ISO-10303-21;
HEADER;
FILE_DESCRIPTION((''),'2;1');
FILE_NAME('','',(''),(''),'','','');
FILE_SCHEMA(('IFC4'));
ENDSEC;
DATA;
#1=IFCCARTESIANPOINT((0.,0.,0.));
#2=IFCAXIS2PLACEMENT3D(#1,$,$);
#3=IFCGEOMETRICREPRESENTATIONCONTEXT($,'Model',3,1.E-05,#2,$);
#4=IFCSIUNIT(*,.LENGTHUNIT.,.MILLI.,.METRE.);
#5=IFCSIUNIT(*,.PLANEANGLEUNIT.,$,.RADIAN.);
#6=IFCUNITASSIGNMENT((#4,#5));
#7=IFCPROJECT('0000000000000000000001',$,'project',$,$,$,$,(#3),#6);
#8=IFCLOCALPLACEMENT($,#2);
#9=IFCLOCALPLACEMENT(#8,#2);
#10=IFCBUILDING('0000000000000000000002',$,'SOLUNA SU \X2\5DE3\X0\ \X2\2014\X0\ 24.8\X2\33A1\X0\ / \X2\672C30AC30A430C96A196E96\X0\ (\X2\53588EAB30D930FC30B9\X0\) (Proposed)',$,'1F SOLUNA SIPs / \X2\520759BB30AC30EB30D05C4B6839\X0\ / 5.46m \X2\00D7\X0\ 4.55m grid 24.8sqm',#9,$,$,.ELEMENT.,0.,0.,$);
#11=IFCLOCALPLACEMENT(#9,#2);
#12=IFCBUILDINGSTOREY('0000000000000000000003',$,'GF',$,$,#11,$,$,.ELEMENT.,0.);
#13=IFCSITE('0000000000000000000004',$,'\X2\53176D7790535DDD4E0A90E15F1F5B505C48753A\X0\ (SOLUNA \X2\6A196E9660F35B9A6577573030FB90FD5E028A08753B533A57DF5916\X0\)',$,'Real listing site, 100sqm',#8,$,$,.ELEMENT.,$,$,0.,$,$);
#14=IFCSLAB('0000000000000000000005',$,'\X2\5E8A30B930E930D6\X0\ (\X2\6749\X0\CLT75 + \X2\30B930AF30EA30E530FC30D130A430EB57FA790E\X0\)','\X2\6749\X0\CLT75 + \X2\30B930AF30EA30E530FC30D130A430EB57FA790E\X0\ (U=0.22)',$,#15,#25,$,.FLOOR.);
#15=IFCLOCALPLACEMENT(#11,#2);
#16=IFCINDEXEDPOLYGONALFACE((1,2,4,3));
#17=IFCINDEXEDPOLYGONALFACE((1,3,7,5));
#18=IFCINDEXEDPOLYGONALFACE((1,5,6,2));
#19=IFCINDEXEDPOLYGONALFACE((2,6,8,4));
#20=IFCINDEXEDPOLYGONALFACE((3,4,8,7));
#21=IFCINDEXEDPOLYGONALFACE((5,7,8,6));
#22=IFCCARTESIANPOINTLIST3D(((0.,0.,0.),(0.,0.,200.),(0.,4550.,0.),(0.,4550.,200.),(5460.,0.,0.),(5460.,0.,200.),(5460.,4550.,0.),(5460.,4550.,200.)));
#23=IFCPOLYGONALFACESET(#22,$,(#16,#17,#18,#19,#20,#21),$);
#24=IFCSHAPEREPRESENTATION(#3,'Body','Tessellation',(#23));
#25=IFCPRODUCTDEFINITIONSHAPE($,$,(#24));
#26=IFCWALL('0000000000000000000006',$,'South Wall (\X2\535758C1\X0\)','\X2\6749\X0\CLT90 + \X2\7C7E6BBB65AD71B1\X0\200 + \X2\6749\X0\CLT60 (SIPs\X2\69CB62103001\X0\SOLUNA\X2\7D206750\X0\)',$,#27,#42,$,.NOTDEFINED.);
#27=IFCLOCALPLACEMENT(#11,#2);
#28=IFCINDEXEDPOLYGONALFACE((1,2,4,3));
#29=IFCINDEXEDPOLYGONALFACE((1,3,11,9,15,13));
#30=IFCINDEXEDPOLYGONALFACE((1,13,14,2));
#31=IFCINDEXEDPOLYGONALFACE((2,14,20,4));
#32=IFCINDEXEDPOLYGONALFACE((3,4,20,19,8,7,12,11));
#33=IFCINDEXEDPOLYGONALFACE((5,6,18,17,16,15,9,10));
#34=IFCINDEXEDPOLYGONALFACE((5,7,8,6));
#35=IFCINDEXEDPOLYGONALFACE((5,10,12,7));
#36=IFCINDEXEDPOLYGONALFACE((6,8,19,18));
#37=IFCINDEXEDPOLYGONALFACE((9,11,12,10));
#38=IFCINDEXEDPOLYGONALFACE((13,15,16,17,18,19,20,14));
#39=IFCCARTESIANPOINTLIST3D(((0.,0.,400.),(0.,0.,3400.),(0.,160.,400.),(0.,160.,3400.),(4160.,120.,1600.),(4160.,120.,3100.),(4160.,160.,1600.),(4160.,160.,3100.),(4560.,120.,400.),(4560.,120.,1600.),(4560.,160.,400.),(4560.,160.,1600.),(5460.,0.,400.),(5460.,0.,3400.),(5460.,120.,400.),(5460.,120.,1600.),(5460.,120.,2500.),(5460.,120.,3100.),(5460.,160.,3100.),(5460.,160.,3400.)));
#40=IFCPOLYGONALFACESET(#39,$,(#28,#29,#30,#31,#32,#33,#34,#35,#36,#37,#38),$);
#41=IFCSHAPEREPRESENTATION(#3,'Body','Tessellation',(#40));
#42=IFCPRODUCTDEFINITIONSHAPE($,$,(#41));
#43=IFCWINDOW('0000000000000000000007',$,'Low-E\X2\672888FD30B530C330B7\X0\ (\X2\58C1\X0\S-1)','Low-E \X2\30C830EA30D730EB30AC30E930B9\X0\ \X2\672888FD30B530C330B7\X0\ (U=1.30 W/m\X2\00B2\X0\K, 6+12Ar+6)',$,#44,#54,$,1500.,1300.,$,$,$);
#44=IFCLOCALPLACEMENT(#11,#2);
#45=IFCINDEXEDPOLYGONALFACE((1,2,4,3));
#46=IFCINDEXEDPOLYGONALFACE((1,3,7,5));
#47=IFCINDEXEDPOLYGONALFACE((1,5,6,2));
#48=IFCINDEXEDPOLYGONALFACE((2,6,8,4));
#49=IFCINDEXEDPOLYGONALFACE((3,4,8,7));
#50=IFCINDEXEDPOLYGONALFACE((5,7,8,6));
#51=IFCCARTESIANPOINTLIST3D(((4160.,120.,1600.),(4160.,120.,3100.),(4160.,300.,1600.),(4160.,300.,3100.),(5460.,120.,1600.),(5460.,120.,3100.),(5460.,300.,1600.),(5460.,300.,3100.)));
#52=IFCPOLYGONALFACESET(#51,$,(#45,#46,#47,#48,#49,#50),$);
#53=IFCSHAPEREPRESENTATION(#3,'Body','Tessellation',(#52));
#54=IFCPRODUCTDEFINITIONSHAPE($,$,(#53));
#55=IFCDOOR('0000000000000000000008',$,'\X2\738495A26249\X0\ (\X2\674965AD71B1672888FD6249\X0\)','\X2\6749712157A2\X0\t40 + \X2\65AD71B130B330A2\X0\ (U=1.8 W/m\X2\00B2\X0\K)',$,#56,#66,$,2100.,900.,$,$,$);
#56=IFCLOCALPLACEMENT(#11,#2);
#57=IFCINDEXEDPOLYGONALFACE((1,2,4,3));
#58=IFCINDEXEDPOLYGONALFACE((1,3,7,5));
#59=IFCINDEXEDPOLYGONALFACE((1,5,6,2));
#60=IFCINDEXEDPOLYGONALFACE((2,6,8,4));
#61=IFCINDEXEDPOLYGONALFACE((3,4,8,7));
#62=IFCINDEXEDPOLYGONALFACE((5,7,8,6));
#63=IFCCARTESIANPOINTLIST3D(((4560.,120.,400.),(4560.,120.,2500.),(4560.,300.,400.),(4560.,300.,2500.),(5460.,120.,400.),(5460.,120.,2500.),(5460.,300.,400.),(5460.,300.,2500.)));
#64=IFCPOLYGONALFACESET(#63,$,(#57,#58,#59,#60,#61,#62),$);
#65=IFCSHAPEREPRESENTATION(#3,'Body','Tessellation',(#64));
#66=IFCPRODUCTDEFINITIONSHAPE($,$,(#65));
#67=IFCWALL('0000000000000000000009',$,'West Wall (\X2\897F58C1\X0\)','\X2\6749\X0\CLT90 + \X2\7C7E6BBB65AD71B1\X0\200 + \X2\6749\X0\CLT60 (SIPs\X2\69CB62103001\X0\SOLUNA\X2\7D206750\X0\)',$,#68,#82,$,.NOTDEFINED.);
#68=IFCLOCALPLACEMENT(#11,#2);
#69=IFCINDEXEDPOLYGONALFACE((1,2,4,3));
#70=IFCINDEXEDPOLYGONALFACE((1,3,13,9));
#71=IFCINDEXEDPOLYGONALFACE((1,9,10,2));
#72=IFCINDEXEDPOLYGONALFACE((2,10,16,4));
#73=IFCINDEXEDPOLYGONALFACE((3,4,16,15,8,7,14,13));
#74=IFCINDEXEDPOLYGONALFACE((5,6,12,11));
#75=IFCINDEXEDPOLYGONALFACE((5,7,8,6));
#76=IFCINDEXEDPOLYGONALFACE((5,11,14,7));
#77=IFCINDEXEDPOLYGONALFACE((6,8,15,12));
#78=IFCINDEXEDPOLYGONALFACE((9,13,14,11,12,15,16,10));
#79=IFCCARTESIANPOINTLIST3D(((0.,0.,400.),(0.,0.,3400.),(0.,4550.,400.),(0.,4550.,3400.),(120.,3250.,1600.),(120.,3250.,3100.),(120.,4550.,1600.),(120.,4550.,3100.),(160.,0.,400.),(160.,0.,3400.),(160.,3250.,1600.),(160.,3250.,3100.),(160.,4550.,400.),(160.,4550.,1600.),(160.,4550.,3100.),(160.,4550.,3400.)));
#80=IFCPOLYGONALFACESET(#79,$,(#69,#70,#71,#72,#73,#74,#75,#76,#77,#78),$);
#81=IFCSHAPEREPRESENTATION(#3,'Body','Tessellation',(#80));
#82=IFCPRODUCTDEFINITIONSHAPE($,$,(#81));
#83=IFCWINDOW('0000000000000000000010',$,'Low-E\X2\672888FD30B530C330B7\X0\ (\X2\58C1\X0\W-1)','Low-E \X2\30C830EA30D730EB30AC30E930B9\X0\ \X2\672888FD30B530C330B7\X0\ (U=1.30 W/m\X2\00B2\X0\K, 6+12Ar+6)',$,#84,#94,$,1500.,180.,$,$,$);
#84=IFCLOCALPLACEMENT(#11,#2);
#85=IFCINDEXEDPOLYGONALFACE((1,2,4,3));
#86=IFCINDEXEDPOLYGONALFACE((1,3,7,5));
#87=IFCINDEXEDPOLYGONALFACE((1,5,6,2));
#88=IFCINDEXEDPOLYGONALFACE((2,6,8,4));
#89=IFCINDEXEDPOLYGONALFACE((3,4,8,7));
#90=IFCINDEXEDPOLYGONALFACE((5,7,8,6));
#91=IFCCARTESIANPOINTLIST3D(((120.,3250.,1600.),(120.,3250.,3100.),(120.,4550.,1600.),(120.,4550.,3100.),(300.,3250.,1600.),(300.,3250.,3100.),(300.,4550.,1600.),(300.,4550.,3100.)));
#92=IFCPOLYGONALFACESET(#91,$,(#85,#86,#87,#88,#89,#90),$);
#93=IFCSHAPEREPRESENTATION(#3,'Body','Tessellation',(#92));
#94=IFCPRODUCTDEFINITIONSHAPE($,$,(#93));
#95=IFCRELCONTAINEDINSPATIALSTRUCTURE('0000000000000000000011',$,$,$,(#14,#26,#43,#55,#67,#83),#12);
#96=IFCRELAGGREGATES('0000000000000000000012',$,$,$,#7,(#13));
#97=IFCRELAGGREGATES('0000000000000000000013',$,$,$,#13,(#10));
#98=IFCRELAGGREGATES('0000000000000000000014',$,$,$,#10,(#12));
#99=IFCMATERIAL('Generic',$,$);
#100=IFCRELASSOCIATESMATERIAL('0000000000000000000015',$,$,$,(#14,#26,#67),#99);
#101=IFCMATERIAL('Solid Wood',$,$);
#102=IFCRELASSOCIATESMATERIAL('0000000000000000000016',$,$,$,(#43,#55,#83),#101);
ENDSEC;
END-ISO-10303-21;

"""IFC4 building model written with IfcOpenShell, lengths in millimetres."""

from ifc_helpers import new_model, si_unit, frame, frame_2d, origin, place, context, project, spatial, rectangle, extrude, material, element, fill, save


model = new_model("IFC4")

# Units and contexts
model_context = context("Model", 3, precision=1e-05, world=origin())
ifc_project = project(units=[si_unit("LENGTHUNIT", "METRE", prefix="MILLI"), si_unit("PLANEANGLEUNIT", "RADIAN")], contexts=[model_context])

# Site, building, storey
site_placement = place(None, origin())
site = spatial("IfcSite", under=ifc_project, at=site_placement, Name="北海道川上郡弟子屈町 (SOLUNA 標準想定敷地・都市計画区域外)", ObjectType="Real listing site, 100sqm", CompositionType="ELEMENT", RefElevation=0.0)
building_placement = place(site_placement, origin())
building = spatial("IfcBuilding", under=site, at=building_placement, Name="SOLUNA SU 巣 — 24.8㎡ / 本ガイド標準 (単身ベース) (Proposed)", ObjectType="1F SOLUNA SIPs / 切妻ガルバ屋根 / 5.46m × 4.55m grid 24.8sqm", CompositionType="ELEMENT", ElevationOfRefHeight=0.0, ElevationOfTerrain=0.0)
storey_placement = place(building_placement, origin())
storey = spatial("IfcBuildingStorey", under=building, at=storey_placement, Name="GF", CompositionType="ELEMENT", Elevation=0.0)

# Slab
ifc_material_1 = material(Name="Generic")
slab_placement = place(storey_placement, origin())
element("IfcSlab", 1, at=slab_placement, inside=storey, material=ifc_material_1, Name="床スラブ (杉CLT75 + スクリューパイル基礎)", Description="杉CLT75 + スクリューパイル基礎 (U=0.22)", PredefinedType="FLOOR", context=model_context, shape_type="SweptSolid", body=[
    extrude(rectangle(XDim=5460.0, YDim=4550.0, at=frame_2d((2730.0, 2275.0))), origin(), (0.0, 0.0, 1.0), 200.0),
])

# Wall, openings, window, door
wall_1_placement = place(storey_placement, frame((0.0, 0.0, 200.0)))
wall_1 = element("IfcWall", 2, at=wall_1_placement, inside=storey, material=ifc_material_1, Name="South Wall (南壁)", Description="杉CLT90 + 籾殻断熱200 + 杉CLT60 (SIPs構成、SOLUNA素材)", PredefinedType="NOTDEFINED", context=model_context, shape_type="SweptSolid", body=[
    extrude(rectangle(XDim=5460.0, YDim=160.0, at=frame_2d((2730.0, 80.0))), frame((0.0, 0.0, 200.0)), (0.0, 0.0, 1.0), 3000.0),
])
opening_1_placement = place(storey_placement, frame((2080.0, 60.0, 800.0)))
opening_1 = element("IfcOpeningElement", 3, at=opening_1_placement, cuts=wall_1, PredefinedType="NOTDEFINED", context=model_context, shape_type="SweptSolid", body=[
    extrude(rectangle(XDim=1300.0, YDim=180.0, at=frame_2d((650.0, 90.0))), frame((2080.0, 60.0, 800.0)), (0.0, 0.0, 1.0), 1500.0),
])
opening_2_placement = place(storey_placement, frame((2280.0, 60.0, 200.0)))
opening_2 = element("IfcOpeningElement", 4, at=opening_2_placement, cuts=wall_1, PredefinedType="NOTDEFINED", context=model_context, shape_type="SweptSolid", body=[
    extrude(rectangle(XDim=900.0, YDim=180.0, at=frame_2d((450.0, 90.0))), frame((2280.0, 60.0, 200.0)), (0.0, 0.0, 1.0), 2100.0),
])
ifc_material_2 = material(Name="Solid Wood")
window_1_placement = place(storey_placement, frame((2080.0, 60.0, 800.0)))
window_1 = element("IfcWindow", 5, at=window_1_placement, inside=storey, material=ifc_material_2, Name="Low-E木製サッシ (壁S-1)", Description="Low-E トリプルガラス 木製サッシ (U=1.30 W/m²K, 6+12Ar+6)", OverallHeight=1500.0, OverallWidth=1300.0, context=model_context, shape_type="SweptSolid", body=[
    extrude(rectangle(XDim=1300.0, YDim=180.0, at=frame_2d((650.0, 90.0))), frame((2080.0, 60.0, 800.0)), (0.0, 0.0, 1.0), 1500.0),
])
fill(opening_1, window_1)
door_placement = place(storey_placement, frame((2280.0, 60.0, 200.0)))
door = element("IfcDoor", 6, at=door_placement, inside=storey, material=ifc_material_2, Name="玄関扉 (杉断熱木製扉)", Description="杉無垢t40 + 断熱コア (U=1.8 W/m²K)", OverallHeight=2100.0, OverallWidth=900.0, context=model_context, shape_type="SweptSolid", body=[
    extrude(rectangle(XDim=900.0, YDim=180.0, at=frame_2d((450.0, 90.0))), frame((2280.0, 60.0, 200.0)), (0.0, 0.0, 1.0), 2100.0),
])
fill(opening_2, door)

# Wall, opening, window
wall_2_placement = place(storey_placement, frame((0.0, 0.0, 200.0)))
wall_2 = element("IfcWall", 7, at=wall_2_placement, inside=storey, material=ifc_material_1, Name="West Wall (西壁)", Description="杉CLT90 + 籾殻断熱200 + 杉CLT60 (SIPs構成、SOLUNA素材)", PredefinedType="NOTDEFINED", context=model_context, shape_type="SweptSolid", body=[
    extrude(rectangle(XDim=160.0, YDim=4550.0, at=frame_2d((80.0, 2275.0))), frame((0.0, 0.0, 200.0)), (0.0, 0.0, 1.0), 3000.0),
])
opening_3_placement = place(storey_placement, frame((60.0, 1625.0, 800.0)))
opening_3 = element("IfcOpeningElement", 8, at=opening_3_placement, cuts=wall_2, PredefinedType="NOTDEFINED", context=model_context, shape_type="SweptSolid", body=[
    extrude(rectangle(XDim=180.0, YDim=1300.0, at=frame_2d((90.0, 650.0))), frame((60.0, 1625.0, 800.0)), (0.0, 0.0, 1.0), 1500.0),
])
window_2_placement = place(storey_placement, frame((60.0, 1625.0, 800.0)))
window_2 = element("IfcWindow", 9, at=window_2_placement, inside=storey, material=ifc_material_2, Name="Low-E木製サッシ (壁W-1)", Description="Low-E トリプルガラス 木製サッシ (U=1.30 W/m²K, 6+12Ar+6)", OverallHeight=1500.0, OverallWidth=180.0, context=model_context, shape_type="SweptSolid", body=[
    extrude(rectangle(XDim=180.0, YDim=1300.0, at=frame_2d((90.0, 650.0))), frame((60.0, 1625.0, 800.0)), (0.0, 0.0, 1.0), 1500.0),
])
fill(opening_3, window_2)

save(model, "model.ifc")
